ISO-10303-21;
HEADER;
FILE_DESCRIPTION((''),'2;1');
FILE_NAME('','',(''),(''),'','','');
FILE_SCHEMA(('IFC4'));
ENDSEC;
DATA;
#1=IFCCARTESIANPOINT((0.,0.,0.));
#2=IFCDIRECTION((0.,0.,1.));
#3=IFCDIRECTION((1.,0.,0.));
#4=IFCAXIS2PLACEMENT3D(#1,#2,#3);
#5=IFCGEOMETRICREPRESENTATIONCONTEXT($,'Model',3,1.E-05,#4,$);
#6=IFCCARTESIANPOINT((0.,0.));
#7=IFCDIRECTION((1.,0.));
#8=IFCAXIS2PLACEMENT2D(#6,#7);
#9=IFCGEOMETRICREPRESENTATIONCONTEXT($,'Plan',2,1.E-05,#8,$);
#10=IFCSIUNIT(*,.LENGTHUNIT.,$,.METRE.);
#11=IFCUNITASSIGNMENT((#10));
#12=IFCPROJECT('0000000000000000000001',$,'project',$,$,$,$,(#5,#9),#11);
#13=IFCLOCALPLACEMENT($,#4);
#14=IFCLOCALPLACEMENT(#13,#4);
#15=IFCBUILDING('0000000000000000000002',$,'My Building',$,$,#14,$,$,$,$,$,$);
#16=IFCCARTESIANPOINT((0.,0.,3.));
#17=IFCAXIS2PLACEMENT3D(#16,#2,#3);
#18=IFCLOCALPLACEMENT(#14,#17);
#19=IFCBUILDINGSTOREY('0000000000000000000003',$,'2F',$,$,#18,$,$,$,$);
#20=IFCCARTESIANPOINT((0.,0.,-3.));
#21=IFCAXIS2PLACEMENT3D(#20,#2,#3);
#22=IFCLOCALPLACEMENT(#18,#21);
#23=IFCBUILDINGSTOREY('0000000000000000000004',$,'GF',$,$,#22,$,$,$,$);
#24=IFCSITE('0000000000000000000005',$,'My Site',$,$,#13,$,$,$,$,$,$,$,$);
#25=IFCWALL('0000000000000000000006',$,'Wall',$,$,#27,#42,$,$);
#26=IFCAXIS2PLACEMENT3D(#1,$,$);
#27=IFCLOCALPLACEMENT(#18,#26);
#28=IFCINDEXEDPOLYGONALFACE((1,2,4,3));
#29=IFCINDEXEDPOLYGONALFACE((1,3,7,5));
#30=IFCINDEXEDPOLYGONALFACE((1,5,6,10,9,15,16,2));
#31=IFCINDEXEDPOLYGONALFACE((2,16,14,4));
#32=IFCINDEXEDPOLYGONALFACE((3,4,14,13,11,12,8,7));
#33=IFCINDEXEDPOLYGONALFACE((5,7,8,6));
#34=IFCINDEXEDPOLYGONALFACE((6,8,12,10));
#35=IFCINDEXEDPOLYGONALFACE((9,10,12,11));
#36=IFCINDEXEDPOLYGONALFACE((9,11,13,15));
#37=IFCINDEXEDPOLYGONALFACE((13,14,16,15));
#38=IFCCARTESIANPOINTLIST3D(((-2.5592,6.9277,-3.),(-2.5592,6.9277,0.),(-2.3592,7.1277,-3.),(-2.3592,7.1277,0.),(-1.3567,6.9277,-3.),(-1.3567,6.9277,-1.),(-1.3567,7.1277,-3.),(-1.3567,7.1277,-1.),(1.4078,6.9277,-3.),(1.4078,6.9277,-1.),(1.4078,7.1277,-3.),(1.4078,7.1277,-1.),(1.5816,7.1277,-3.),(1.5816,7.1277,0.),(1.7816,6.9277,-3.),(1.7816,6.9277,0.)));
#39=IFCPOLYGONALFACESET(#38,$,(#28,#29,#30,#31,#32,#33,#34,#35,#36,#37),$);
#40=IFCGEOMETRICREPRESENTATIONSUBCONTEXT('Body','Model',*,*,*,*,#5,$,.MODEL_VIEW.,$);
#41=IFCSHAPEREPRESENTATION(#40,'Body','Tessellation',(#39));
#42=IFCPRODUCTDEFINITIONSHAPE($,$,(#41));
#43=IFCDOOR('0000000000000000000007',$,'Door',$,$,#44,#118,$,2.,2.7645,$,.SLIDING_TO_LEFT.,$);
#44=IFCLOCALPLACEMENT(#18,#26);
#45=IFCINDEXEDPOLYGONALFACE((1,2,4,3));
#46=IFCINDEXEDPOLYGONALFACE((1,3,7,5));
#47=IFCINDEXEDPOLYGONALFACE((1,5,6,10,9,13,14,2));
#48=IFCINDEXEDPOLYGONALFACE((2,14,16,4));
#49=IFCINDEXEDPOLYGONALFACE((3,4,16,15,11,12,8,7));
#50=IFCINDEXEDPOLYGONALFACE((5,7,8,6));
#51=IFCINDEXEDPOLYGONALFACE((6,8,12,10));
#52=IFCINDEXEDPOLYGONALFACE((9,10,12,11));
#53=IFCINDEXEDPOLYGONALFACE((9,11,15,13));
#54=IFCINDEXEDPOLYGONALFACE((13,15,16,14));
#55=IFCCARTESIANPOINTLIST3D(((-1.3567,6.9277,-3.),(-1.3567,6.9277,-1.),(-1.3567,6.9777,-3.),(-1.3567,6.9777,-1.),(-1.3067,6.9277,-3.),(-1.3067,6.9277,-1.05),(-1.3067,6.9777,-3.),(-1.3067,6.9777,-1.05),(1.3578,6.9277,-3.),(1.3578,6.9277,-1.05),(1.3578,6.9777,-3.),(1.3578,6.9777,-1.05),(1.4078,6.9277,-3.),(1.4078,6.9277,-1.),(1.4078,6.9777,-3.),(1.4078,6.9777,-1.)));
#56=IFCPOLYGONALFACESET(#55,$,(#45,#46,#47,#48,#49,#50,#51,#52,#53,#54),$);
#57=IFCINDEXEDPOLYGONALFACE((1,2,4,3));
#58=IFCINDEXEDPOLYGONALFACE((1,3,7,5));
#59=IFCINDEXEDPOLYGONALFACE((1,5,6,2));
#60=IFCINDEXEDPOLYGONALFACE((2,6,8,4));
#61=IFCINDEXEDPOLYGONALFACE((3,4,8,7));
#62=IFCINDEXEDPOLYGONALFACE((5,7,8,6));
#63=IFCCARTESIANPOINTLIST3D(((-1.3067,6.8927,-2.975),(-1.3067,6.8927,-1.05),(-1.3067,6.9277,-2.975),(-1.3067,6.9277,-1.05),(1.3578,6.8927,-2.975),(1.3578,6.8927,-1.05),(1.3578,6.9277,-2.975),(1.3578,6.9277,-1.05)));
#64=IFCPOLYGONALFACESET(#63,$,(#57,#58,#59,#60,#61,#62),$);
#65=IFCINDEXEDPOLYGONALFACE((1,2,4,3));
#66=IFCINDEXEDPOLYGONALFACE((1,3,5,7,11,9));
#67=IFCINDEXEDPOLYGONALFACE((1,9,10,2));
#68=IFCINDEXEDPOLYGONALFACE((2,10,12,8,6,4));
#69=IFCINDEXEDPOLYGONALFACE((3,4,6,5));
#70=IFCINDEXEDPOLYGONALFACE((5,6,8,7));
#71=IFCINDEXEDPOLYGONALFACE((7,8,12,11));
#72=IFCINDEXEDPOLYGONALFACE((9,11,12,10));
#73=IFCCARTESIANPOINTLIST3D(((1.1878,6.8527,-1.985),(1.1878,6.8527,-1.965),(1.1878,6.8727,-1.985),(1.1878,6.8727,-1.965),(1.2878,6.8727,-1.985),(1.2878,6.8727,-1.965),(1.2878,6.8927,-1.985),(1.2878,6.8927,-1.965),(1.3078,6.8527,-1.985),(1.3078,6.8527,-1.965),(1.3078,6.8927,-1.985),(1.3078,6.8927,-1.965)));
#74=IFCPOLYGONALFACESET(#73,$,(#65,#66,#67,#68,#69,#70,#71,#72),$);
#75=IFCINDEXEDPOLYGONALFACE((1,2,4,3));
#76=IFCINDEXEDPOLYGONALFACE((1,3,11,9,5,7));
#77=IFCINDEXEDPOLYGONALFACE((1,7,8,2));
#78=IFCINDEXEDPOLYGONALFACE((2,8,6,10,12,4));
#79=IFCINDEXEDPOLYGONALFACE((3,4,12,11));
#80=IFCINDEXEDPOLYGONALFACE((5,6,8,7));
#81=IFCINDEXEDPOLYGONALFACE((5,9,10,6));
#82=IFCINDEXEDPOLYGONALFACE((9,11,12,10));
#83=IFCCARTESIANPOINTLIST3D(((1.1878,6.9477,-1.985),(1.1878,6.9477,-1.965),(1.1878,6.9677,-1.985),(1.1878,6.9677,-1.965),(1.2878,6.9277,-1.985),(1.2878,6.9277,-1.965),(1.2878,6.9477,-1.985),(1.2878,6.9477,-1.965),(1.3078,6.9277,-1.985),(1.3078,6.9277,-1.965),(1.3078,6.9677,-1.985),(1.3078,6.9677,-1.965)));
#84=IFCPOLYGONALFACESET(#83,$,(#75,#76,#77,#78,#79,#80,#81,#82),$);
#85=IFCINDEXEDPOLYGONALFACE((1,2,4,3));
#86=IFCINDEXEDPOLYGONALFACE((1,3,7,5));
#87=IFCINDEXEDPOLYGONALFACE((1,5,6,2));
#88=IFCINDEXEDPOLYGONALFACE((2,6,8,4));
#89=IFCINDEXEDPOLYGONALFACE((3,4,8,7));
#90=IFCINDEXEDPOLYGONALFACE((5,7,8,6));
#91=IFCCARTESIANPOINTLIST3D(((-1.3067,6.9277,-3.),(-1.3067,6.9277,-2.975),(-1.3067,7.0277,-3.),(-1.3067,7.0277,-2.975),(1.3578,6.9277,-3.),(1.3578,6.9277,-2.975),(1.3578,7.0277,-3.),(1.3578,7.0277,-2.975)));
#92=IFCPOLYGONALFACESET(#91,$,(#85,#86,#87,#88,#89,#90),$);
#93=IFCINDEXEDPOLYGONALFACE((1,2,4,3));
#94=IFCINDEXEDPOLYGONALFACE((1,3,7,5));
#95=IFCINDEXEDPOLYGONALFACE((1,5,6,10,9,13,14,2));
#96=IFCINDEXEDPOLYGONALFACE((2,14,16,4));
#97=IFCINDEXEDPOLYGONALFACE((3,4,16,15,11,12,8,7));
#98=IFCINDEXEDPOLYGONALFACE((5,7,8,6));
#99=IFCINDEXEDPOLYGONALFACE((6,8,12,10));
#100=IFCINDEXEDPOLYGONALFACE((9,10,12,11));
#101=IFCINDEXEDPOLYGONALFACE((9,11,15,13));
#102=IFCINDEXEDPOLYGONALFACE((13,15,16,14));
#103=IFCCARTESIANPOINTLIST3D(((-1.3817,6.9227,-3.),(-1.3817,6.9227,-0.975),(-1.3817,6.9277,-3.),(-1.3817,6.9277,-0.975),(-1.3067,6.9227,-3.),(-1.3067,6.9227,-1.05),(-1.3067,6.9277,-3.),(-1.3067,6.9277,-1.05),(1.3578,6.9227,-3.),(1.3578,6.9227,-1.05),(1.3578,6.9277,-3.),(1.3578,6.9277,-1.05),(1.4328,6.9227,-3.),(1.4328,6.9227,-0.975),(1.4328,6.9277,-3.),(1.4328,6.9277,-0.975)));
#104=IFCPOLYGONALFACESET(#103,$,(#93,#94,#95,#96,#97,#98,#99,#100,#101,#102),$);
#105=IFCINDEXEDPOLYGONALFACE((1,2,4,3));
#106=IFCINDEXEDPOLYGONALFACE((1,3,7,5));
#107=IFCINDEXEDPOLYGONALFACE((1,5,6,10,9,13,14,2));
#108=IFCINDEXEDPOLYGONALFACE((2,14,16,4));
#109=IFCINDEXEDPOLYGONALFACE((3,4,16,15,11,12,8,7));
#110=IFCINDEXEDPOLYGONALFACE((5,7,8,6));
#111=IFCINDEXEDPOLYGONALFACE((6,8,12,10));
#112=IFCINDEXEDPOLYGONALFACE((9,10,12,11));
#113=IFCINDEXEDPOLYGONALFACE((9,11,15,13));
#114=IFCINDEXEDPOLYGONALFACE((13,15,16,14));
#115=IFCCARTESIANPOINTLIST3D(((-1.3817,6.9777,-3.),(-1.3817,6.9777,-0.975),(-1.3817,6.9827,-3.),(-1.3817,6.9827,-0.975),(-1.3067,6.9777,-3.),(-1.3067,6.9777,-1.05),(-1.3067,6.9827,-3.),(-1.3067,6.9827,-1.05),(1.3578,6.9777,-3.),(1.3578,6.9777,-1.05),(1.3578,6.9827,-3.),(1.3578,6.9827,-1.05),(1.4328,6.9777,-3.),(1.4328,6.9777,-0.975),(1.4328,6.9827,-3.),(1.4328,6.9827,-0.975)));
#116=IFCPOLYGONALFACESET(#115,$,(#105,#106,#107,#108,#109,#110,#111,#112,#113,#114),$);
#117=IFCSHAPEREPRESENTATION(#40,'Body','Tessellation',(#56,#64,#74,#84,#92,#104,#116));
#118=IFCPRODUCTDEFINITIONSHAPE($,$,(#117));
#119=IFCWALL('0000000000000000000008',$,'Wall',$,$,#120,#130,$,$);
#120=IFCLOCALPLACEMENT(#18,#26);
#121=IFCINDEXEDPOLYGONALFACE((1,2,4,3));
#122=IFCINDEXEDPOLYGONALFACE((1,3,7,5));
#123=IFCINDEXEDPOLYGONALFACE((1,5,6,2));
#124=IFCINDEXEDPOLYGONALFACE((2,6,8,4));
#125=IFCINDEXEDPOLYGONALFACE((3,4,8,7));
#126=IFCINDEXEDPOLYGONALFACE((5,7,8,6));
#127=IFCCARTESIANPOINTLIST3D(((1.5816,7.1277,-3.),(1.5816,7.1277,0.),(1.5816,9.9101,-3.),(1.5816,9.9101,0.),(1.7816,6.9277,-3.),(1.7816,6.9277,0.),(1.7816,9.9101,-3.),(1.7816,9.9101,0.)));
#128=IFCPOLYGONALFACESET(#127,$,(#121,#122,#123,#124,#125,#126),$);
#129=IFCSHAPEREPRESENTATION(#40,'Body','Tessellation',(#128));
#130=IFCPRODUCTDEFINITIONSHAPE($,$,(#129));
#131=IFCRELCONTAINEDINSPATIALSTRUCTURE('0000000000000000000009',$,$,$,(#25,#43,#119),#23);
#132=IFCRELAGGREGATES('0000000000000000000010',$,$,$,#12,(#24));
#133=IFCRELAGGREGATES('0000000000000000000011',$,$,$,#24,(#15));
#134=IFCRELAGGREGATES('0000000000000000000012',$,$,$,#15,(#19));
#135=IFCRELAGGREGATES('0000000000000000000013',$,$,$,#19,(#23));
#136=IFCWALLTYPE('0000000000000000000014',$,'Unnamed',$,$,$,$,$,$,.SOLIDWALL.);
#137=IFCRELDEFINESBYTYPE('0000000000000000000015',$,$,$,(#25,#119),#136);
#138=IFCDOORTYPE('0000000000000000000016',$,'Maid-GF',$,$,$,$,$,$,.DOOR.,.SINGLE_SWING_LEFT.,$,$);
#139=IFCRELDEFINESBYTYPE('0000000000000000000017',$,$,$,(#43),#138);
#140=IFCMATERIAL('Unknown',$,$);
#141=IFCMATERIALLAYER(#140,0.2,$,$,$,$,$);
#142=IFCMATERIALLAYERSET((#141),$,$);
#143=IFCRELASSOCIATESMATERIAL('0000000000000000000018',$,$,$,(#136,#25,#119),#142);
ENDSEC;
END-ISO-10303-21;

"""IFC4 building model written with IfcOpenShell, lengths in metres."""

from ifc_helpers import new_model, entity, si_unit, frame, origin_with_axes, origin_2d_with_axis, place, context, subcontext, project, spatial, line, indexed_curve, outline, extrude, shape, source, transform, mapped, material, layer, layer_set, layer_usage, type_object, type_shapes, element, fill, save


model = new_model("IFC4")

# Units and contexts
model_context = context("Model", 3, precision=1e-05, world=origin_with_axes())
plan_context = context("Plan", 2, precision=1e-05, world=origin_2d_with_axis())
body_context_1 = subcontext(model_context, "Body", "Model", "MODEL_VIEW")
body_context_2 = subcontext(plan_context, "Body", "Plan", "PLAN_VIEW")
ifc_project = project(units=[si_unit("LENGTHUNIT", "METRE")], contexts=[model_context, plan_context])

# Site, building, storeys
site_placement = place(None, origin_with_axes())
site = spatial("IfcSite", under=ifc_project, at=site_placement, Name="My Site")
building_placement = place(site_placement, origin_with_axes())
building = spatial("IfcBuilding", under=site, at=building_placement, Name="My Building")
storey_1_placement = place(building_placement, frame((0.0, 0.0, 3.0), z_axis=(0.0, 0.0, 1.0), x_axis=(1.0, 0.0, 0.0)))
storey_1 = spatial("IfcBuildingStorey", under=building, at=storey_1_placement, Name="2F")
storey_2_placement = place(storey_1_placement, frame((0.0, 0.0, -3.0), z_axis=(0.0, 0.0, 1.0), x_axis=(1.0, 0.0, 0.0)))
storey_2 = spatial("IfcBuildingStorey", under=storey_1, at=storey_2_placement, Name="GF")

# Shared definitions
ifc_material = material(Name="Unknown")

# Shared definitions
ifc_layer_1 = layer(ifc_material, 0.2)
ifc_layer_set_1 = layer_set([ifc_layer_1])
wall_type = type_object("IfcWallType", Name="Unnamed", PredefinedType="SOLIDWALL", material=ifc_layer_set_1)

# Wall, opening, door
ifc_layer_usage_1 = layer_usage(ifc_layer_set_1, "AXIS2", "POSITIVE", 0.0)
wall_1_placement = place(storey_2_placement, frame((-2.5592, 6.9277, 0.0), z_axis=(0.0, 0.0, 1.0), x_axis=(1.0, 0.0, 0.0)))
wall_1 = element("IfcWall", 1, at=wall_1_placement, inside=storey_2, type_object=wall_type, material=ifc_layer_usage_1, Name="Wall", context=body_context_1, shape_type="SweptSolid", body=[
    extrude(outline(indexed_curve([(0.0, 0.0), (0.2, 0.2), (4.1408, 0.2), (4.3408, 0.0)], segments=[line(1, 2, 3, 4, 1)])), origin_with_axes(), (0.0, 0.0, 1.0), 3.0),
])
shared_shape_1 = source(origin_with_axes(), body_context_1, "Body", "SweptSolid", [
    extrude(outline(indexed_curve([(0.0, 0.0), (2.7645, 0.0), (2.7645, 2.0), (0.0, 2.0)], segments=[line(1, 2, 3, 4, 1)])), frame((0.0, -0.6, 0.0), z_axis=(0.0, -1.0, 0.0), x_axis=(1.0, 0.0, 0.0)), (0.0, 0.0, -1.0), 1.2),
])
opening_1_placement = place(wall_1_placement, frame((1.2026, 0.0, 0.0), z_axis=(0.0, 0.0, 1.0), x_axis=(1.0, 0.0, 0.0)))
opening_1 = element("IfcOpeningElement", 2, at=opening_1_placement, cuts=wall_1, PredefinedType="OPENING", context=body_context_1, shape_type="MappedRepresentation", body=[
    mapped(shared_shape_1, transform((0.0, 0.0, 0.0), x_axis=(1.0, 0.0, 0.0), y_axis=(0.0, 1.0, 0.0), z_axis=(0.0, 0.0, 1.0), scale=1.0)),
])
door_type_1 = type_object("IfcDoorType", Name="Maid-GF", OperationType="SINGLE_SWING_LEFT", PredefinedType="DOOR")
shared_shape_2 = source(origin_with_axes(), body_context_1, "Body", "SweptSolid", [
    extrude(outline(indexed_curve([(0.0, 0.0), (0.0, 2.0), (2.7645, 2.0), (2.7645, 0.0), (2.7145, 0.0), (2.7145, 1.95), (0.05, 1.95), (0.05, 0.0)], segments=[line(1, 2, 3, 4, 5, 6, 7, 8, 1)])), frame((0.0, 0.0, 0.0), z_axis=(0.0, -1.0, 0.0), x_axis=(1.0, 0.0, 0.0)), (0.0, 0.0, -1.0), 0.05),
    extrude(outline(indexed_curve([(0.0, 0.0), (2.6645, 0.0), (2.6645, 0.035), (0.0, 0.035)], segments=[line(1, 2, 3, 4, 1)])), frame((0.05, -0.035, 0.025), z_axis=(0.0, 0.0, 1.0), x_axis=(1.0, 0.0, 0.0)), (0.0, 0.0, 1.0), 1.925),
    extrude(outline(indexed_curve([(0.0, 0.0), (0.0, -0.04), (-0.12, -0.04), (-0.12, -0.02), (-0.02, -0.02), (-0.02, 0.0)], segments=[line(1, 2, 3, 4, 5, 6, 1)])), frame((2.6645, -0.035, 1.015), z_axis=(0.0, 0.0, 1.0), x_axis=(1.0, 0.0, 0.0)), (0.0, 0.0, 1.0), 0.02),
    extrude(outline(indexed_curve([(0.0, 0.0), (0.0, 0.04), (-0.12, 0.04), (-0.12, 0.02), (-0.02, 0.02), (-0.02, 0.0)], segments=[line(1, 2, 3, 4, 5, 6, 1)])), frame((2.6645, 0.0, 1.015), z_axis=(0.0, 0.0, 1.0), x_axis=(1.0, 0.0, 0.0)), (0.0, 0.0, 1.0), 0.02),
    extrude(outline(indexed_curve([(0.0, 0.0), (2.6645, 0.0), (2.6645, 0.1), (0.0, 0.1)], segments=[line(1, 2, 3, 4, 1)])), frame((0.05, 0.0, 0.0), z_axis=(0.0, 0.0, 1.0), x_axis=(1.0, 0.0, 0.0)), (0.0, 0.0, 1.0), 0.025),
    extrude(outline(indexed_curve([(0.0, 0.0), (0.0, 2.025), (2.8145, 2.025), (2.8145, 0.0), (2.7395, 0.0), (2.7395, 1.95), (0.075, 1.95), (0.075, 0.0)], segments=[line(1, 2, 3, 4, 5, 6, 7, 8, 1)])), frame((-0.025, -0.005, 0.0), z_axis=(0.0, -1.0, 0.0), x_axis=(1.0, 0.0, 0.0)), (0.0, 0.0, -1.0), 0.005),
    extrude(outline(indexed_curve([(0.0, 0.0), (0.0, 2.025), (2.8145, 2.025), (2.8145, 0.0), (2.7395, 0.0), (2.7395, 1.95), (0.075, 1.95), (0.075, 0.0)], segments=[line(1, 2, 3, 4, 5, 6, 7, 8, 1)])), frame((-0.025, 0.05, 0.0), z_axis=(0.0, -1.0, 0.0), x_axis=(1.0, 0.0, 0.0)), (0.0, 0.0, -1.0), 0.005),
])
shared_shape_3 = source(origin_with_axes(), body_context_2, "Body", "Curve2D", [
    entity("IfcIndexedPolyCurve", entity("IfcCartesianPointList2D", [[0.0, 0.0], [0.05, 0.0], [0.05, 0.05], [0.0, 0.05]]), [entity("IfcLineIndex", [1, 2, 3, 4, 1])]),
    entity("IfcIndexedPolyCurve", entity("IfcCartesianPointList2D", [[2.7645, 0.0], [2.7145, 0.0], [2.7145, 0.05], [2.7645, 0.05]]), [entity("IfcLineIndex", [1, 2, 3, 4, 1])]),
    entity("IfcIndexedPolyCurve", entity("IfcCartesianPointList2D", [[-1.2823, -0.035], [1.3823, -0.035], [1.3823, 0.0], [-1.2823, 0.0]]), [entity("IfcLineIndex", [1, 2, 3, 4, 1])]),
])
type_shapes(door_type_1, [shared_shape_2, shared_shape_3])
door_1_placement = place(opening_1_placement, origin_with_axes())
door_1 = element("IfcDoor", 3, at=door_1_placement, inside=storey_2, type_object=door_type_1, Name="Door", OperationType="SLIDING_TO_LEFT", OverallHeight=2.0, OverallWidth=2.7645, shapes=[
    shape(body_context_1, "Body", "MappedRepresentation", [mapped(shared_shape_2, transform((0.0, 0.0, 0.0), x_axis=(1.0, 0.0, 0.0), y_axis=(0.0, 1.0, 0.0), z_axis=(0.0, 0.0, 1.0), scale=1.0))]),
    shape(body_context_2, "Body", "MappedRepresentation", [mapped(shared_shape_3, transform((0.0, 0.0, 0.0), x_axis=(1.0, 0.0, 0.0), y_axis=(0.0, 1.0, 0.0), z_axis=(0.0, 0.0, 1.0), scale=1.0))]),
])
fill(opening_1, door_1)

# Wall
ifc_layer_usage_2 = layer_usage(ifc_layer_set_1, "AXIS2", "POSITIVE", 0.0)
wall_2_placement = place(storey_2_placement, frame((1.7816, 6.9277, 0.0), z_axis=(0.0, 0.0, 1.0), x_axis=(0.0, 1.0, 0.0)))
element("IfcWall", 4, at=wall_2_placement, inside=storey_2, type_object=wall_type, material=ifc_layer_usage_2, Name="Wall", context=body_context_1, shape_type="SweptSolid", body=[
    extrude(outline(indexed_curve([(0.0, 0.0), (0.2, 0.2), (2.9823, 0.2), (2.9823, 0.0)], segments=[line(1, 2, 3, 4, 1)])), origin_with_axes(), (0.0, 0.0, 1.0), 3.0),
])

save(model, "model.ifc")
